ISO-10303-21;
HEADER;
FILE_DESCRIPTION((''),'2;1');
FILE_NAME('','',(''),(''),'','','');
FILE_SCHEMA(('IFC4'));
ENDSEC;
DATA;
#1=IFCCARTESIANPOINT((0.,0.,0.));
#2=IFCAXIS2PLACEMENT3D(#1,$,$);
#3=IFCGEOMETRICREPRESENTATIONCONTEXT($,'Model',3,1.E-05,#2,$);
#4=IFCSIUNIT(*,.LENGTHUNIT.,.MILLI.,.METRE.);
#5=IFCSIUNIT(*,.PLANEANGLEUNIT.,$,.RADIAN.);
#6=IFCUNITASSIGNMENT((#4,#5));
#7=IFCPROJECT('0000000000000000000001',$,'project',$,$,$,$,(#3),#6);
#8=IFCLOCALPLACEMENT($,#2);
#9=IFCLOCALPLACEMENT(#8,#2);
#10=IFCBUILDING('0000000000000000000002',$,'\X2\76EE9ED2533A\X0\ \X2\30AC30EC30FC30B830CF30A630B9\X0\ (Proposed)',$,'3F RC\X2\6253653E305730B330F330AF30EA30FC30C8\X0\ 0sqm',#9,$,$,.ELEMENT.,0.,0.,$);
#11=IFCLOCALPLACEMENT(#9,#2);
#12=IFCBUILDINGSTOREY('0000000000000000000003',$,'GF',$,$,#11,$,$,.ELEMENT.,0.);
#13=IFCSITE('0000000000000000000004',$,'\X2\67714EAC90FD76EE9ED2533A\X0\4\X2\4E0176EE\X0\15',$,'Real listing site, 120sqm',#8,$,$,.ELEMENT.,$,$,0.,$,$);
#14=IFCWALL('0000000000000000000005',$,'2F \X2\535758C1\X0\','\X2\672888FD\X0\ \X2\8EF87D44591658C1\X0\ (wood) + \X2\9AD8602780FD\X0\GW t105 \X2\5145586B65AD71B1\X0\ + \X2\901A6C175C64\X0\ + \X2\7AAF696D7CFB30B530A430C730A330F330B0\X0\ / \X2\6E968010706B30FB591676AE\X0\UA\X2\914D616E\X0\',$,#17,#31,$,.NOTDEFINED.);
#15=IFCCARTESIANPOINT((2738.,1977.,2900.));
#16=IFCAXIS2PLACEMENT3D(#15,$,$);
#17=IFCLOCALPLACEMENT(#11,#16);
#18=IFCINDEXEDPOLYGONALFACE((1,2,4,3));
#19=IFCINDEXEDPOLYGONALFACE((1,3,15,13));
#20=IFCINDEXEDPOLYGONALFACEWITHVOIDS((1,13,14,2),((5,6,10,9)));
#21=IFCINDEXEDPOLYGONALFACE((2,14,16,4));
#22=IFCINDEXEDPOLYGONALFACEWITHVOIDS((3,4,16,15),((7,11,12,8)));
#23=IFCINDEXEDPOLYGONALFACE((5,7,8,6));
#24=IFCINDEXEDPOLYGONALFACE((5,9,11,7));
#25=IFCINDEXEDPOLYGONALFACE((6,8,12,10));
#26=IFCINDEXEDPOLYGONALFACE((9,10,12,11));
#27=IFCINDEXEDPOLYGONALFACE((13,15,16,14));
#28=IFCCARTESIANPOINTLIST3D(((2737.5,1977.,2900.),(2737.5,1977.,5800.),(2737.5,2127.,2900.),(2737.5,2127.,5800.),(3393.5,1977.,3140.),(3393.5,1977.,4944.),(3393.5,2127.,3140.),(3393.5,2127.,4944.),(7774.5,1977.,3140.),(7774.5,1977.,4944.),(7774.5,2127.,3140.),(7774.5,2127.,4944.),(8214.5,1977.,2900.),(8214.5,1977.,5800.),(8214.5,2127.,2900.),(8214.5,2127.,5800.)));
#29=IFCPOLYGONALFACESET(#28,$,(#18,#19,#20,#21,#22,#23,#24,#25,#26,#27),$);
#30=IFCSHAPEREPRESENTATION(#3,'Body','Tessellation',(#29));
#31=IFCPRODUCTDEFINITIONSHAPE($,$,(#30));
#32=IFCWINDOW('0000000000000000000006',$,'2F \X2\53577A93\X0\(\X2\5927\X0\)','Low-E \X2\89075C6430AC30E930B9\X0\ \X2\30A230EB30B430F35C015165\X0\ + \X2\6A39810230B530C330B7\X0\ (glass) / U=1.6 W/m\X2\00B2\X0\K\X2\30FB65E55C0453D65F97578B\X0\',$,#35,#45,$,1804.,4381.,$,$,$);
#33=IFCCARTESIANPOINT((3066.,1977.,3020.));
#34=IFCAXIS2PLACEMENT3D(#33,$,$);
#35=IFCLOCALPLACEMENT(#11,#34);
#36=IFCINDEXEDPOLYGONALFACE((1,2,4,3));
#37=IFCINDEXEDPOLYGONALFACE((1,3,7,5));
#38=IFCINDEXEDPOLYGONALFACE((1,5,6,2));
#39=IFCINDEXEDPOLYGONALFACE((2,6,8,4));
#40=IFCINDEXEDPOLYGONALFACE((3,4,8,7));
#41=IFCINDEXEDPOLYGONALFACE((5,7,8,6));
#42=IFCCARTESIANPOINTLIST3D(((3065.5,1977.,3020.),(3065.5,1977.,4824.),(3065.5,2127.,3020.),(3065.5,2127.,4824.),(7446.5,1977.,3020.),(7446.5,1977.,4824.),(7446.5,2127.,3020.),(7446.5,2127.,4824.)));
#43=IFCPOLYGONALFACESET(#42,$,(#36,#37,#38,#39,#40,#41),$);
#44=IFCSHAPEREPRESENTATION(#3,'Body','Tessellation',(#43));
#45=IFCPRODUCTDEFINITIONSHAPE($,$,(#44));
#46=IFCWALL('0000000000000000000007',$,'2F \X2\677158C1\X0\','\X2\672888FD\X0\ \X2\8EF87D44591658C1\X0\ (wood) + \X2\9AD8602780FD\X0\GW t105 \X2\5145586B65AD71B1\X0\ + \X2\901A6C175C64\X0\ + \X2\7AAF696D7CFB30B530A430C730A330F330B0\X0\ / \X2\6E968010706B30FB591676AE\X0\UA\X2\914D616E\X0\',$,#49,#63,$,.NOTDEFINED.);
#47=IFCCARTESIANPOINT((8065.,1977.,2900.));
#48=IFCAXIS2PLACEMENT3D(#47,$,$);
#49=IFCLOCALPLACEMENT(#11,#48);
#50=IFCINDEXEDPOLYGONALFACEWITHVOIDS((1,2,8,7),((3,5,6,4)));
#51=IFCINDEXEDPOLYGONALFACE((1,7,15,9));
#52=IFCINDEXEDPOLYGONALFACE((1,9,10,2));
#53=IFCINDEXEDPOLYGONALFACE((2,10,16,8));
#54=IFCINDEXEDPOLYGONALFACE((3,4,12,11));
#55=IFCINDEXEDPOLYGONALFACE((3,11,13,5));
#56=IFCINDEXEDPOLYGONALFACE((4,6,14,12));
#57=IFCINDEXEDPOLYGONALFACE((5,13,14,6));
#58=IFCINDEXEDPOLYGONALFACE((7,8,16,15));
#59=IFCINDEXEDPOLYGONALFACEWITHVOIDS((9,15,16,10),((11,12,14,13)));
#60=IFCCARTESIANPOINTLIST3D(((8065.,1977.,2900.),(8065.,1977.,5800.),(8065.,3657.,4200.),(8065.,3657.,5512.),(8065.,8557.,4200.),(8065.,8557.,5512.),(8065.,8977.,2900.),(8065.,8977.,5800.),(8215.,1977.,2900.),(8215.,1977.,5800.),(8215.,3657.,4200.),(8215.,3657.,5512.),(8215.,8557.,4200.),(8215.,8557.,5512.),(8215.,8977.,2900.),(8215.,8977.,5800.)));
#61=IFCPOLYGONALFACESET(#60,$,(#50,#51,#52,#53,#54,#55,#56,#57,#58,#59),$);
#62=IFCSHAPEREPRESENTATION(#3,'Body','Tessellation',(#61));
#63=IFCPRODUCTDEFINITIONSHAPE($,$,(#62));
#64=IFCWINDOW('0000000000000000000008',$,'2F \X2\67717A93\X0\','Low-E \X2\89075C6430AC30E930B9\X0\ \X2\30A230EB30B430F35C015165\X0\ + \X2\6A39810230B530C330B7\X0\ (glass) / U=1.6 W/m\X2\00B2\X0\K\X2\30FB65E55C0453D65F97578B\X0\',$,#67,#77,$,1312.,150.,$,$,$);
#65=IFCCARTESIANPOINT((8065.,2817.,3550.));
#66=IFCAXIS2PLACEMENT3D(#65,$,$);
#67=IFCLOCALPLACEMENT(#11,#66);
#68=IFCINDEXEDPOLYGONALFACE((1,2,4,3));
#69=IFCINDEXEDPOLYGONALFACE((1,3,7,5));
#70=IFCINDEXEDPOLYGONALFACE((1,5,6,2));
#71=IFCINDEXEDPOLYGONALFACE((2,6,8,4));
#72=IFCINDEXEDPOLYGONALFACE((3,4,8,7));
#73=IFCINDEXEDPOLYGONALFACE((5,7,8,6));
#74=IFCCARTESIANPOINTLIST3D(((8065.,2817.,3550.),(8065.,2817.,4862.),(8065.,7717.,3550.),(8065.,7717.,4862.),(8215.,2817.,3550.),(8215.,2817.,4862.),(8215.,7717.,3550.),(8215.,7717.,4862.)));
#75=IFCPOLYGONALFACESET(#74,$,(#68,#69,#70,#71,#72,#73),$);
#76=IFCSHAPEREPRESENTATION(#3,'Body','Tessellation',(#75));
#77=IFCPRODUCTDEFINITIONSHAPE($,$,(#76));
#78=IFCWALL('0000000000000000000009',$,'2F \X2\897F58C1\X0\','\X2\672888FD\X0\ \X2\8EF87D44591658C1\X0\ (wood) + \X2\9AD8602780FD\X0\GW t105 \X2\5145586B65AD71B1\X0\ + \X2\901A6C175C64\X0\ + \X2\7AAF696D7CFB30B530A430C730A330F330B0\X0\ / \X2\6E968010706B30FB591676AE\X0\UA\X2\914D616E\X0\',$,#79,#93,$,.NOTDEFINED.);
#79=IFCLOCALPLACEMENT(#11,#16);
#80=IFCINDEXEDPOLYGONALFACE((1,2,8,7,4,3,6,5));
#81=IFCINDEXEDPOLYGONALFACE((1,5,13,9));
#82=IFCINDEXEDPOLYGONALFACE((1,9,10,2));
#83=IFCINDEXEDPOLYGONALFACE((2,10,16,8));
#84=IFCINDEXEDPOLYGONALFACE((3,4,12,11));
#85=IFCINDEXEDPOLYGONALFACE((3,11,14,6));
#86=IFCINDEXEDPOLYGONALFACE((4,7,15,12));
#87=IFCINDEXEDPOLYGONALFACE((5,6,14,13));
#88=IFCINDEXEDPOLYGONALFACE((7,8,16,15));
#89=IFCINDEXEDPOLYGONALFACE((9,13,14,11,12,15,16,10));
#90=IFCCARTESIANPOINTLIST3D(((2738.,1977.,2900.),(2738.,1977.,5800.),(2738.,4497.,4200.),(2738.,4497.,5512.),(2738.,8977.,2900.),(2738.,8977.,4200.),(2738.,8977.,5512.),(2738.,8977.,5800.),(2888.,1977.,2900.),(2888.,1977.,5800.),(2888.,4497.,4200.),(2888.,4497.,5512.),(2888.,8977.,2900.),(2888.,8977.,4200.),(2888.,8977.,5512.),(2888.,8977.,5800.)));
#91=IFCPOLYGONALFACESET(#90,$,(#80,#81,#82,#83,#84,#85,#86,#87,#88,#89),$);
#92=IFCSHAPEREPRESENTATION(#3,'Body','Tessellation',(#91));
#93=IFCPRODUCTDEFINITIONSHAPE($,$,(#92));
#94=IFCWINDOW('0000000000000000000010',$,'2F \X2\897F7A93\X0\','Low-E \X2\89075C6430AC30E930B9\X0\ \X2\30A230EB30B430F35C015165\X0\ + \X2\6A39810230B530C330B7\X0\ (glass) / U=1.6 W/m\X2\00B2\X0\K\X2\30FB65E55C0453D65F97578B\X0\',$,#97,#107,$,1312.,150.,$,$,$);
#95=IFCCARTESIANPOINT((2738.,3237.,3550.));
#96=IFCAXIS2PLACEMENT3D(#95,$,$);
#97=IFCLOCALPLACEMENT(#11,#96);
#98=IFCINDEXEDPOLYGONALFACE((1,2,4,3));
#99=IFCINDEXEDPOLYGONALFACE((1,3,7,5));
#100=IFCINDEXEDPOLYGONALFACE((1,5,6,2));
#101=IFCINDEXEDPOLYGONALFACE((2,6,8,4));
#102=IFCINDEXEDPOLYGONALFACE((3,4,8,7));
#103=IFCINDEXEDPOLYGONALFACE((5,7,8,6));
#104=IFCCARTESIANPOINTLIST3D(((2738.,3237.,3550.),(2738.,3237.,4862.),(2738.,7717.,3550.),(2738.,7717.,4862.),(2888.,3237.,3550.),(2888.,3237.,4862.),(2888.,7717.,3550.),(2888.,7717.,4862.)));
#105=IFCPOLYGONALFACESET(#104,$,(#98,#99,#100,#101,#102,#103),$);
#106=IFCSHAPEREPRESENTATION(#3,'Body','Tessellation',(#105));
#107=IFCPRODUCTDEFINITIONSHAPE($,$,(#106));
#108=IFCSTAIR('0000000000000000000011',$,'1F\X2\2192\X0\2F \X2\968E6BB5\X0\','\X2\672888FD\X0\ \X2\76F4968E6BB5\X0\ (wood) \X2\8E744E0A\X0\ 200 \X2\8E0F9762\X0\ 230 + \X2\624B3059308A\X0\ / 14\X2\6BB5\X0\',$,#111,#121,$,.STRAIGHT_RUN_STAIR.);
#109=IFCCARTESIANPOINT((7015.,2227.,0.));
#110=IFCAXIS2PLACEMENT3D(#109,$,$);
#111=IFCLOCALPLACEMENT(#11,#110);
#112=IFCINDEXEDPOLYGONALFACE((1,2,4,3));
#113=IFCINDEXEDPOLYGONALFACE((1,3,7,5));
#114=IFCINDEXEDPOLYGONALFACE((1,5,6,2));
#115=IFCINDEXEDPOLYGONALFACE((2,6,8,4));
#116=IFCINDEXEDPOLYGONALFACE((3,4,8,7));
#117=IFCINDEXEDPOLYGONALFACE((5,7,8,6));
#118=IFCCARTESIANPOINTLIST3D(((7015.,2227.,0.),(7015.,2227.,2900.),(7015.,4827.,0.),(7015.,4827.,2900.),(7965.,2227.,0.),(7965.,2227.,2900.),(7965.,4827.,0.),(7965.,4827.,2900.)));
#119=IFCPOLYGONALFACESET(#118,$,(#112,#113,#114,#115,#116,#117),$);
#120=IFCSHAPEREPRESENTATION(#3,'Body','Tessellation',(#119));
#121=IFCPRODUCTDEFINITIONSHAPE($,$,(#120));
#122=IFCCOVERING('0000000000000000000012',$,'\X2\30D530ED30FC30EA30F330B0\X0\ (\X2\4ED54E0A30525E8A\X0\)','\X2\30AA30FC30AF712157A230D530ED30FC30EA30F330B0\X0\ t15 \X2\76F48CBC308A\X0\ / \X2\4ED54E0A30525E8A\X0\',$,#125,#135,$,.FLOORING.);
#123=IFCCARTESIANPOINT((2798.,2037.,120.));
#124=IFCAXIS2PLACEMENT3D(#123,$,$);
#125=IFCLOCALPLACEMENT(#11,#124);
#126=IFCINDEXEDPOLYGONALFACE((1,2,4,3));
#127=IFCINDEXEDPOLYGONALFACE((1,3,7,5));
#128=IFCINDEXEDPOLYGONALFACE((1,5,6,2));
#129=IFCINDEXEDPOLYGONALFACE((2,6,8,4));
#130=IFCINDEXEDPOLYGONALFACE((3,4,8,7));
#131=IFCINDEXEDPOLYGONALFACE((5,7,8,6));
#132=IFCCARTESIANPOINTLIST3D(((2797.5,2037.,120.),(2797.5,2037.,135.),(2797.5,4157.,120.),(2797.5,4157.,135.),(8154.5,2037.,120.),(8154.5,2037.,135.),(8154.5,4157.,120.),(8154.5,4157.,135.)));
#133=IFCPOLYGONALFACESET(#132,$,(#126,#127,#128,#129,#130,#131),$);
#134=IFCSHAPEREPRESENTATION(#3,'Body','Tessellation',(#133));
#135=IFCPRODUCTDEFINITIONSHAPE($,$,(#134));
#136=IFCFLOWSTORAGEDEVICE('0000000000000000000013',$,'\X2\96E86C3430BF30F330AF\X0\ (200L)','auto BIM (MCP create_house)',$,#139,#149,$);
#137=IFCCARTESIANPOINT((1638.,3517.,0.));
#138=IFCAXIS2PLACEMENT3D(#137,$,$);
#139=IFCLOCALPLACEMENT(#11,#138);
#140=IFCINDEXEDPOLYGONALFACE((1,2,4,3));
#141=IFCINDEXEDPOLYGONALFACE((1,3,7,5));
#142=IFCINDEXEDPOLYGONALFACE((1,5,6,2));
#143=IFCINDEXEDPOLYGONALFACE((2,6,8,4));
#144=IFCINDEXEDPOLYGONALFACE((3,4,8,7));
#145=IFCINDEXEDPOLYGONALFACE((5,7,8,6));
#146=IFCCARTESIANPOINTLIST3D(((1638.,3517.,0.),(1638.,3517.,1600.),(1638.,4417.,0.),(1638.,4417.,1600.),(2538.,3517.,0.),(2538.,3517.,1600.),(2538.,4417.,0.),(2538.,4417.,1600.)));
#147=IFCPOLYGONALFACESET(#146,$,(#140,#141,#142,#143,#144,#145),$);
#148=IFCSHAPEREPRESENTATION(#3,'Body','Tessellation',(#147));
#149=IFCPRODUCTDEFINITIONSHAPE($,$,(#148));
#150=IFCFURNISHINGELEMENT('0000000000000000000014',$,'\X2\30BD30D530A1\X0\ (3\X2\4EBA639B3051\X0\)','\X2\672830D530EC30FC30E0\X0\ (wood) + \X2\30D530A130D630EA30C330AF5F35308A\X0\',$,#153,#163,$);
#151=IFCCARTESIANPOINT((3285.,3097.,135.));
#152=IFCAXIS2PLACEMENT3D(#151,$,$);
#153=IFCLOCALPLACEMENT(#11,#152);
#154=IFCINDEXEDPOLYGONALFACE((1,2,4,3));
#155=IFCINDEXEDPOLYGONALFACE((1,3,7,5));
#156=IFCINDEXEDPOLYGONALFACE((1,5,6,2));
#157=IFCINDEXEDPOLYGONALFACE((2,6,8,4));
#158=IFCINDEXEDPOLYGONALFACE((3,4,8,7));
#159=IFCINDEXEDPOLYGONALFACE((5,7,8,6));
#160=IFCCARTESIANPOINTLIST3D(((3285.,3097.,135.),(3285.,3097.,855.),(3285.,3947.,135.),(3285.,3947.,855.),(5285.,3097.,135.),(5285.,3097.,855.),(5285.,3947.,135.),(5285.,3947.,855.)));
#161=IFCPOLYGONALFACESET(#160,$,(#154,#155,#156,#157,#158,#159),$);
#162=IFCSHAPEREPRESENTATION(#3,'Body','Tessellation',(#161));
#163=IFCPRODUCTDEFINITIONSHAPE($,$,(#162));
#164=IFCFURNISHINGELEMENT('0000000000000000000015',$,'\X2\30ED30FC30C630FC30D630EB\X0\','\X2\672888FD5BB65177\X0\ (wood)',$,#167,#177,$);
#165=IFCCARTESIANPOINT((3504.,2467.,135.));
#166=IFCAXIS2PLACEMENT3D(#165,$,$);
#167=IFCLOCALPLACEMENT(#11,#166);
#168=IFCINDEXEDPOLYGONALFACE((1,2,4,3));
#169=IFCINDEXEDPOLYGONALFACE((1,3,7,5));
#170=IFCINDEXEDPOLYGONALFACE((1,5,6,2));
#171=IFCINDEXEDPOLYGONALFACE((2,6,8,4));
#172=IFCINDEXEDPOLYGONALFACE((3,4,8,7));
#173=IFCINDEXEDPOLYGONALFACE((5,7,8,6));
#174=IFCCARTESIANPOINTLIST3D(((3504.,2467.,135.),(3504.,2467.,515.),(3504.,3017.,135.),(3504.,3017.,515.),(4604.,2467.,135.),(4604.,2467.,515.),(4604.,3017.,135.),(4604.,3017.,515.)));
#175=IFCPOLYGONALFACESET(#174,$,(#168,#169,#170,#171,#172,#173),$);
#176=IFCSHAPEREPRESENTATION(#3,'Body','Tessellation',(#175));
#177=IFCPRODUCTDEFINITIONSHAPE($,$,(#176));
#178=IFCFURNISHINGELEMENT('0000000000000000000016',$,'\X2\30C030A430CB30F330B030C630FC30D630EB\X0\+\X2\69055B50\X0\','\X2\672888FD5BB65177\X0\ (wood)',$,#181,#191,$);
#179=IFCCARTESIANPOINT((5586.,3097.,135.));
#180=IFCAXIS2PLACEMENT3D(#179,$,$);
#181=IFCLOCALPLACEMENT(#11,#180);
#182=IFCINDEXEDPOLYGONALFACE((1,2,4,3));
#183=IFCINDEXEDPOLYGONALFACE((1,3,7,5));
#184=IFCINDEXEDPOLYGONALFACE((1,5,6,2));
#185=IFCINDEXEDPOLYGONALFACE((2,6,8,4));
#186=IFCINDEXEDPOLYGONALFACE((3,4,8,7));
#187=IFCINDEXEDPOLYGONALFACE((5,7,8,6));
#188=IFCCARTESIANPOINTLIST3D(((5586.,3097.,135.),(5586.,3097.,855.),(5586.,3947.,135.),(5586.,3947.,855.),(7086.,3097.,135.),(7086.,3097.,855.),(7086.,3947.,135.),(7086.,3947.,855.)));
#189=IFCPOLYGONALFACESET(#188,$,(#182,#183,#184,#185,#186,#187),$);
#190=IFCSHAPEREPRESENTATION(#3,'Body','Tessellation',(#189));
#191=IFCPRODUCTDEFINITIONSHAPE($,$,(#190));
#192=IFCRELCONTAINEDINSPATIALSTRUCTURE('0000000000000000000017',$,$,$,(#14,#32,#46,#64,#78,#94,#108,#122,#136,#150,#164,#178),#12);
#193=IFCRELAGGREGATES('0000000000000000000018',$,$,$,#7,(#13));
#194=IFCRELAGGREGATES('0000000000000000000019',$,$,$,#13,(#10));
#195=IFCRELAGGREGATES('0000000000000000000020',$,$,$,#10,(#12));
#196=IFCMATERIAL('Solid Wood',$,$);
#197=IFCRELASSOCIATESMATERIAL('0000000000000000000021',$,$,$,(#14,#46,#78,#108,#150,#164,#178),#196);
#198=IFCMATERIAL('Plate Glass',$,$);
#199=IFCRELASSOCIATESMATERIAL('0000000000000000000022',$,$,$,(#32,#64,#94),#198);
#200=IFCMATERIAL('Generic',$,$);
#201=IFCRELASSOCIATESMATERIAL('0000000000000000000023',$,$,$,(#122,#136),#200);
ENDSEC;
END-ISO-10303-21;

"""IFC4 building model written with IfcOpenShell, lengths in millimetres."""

from ifc_helpers import new_model, si_unit, frame, frame_2d, origin, place, context, project, spatial, rectangle, extrude, material, element, fill, save


model = new_model("IFC4")

# Units and contexts
model_context = context("Model", 3, precision=1e-05, world=origin())
ifc_project = project(units=[si_unit("LENGTHUNIT", "METRE", prefix="MILLI"), si_unit("PLANEANGLEUNIT", "RADIAN")], contexts=[model_context])

# Site, building, storey
site_placement = place(None, origin())
site = spatial("IfcSite", under=ifc_project, at=site_placement, Name="東京都目黒区4丁目15", ObjectType="Real listing site, 120sqm", CompositionType="ELEMENT", RefElevation=0.0)
building_placement = place(site_placement, origin())
building = spatial("IfcBuilding", under=site, at=building_placement, Name="目黒区 ガレージハウス (Proposed)", ObjectType="3F RC打放しコンクリート 0sqm", CompositionType="ELEMENT", ElevationOfRefHeight=0.0, ElevationOfTerrain=0.0)
storey_placement = place(building_placement, origin())
storey = spatial("IfcBuildingStorey", under=building, at=storey_placement, Name="GF", CompositionType="ELEMENT", Elevation=0.0)

# Shared definitions
ifc_material_1 = material(Name="Solid Wood")

# Shared definitions
ifc_material_2 = material(Name="Plate Glass")

# Walls, openings, windows
wall_1_placement = place(storey_placement, frame((2738.0, 1977.0, 2900.0)))
wall_1 = element("IfcWall", 1, at=wall_1_placement, inside=storey, material=ifc_material_1, Name="2F 南壁", Description="木製 軸組外壁 (wood) + 高性能GW t105 充填断熱 + 通気層 + 窯業系サイディング / 準耐火・外皮UA配慮", PredefinedType="NOTDEFINED", context=model_context, shape_type="SweptSolid", body=[
    extrude(rectangle(XDim=5477.0, YDim=150.0, at=frame_2d((2738.0, 75.0))), frame((2738.0, 1977.0, 2900.0)), (0.0, 0.0, 1.0), 2900.0),
])
opening_1_placement = place(storey_placement, frame((3066.0, 1977.0, 3020.0)))
opening_1 = element("IfcOpeningElement", 2, at=opening_1_placement, cuts=wall_1, PredefinedType="NOTDEFINED", context=model_context, shape_type="SweptSolid", body=[
    extrude(rectangle(XDim=4381.0, YDim=150.0, at=frame_2d((2190.0, 75.0))), frame((3066.0, 1977.0, 3020.0)), (0.0, 0.0, 1.0), 1804.0),
])
window_1_placement = place(storey_placement, frame((3066.0, 1977.0, 3020.0)))
window_1 = element("IfcWindow", 3, at=window_1_placement, inside=storey, material=ifc_material_2, Name="2F 南窓(大)", Description="Low-E 複層ガラス アルゴン封入 + 樹脂サッシ (glass) / U=1.6 W/m²K・日射取得型", OverallHeight=1804.0, OverallWidth=4381.0, context=model_context, shape_type="SweptSolid", body=[
    extrude(rectangle(XDim=4381.0, YDim=150.0, at=frame_2d((2190.0, 75.0))), frame((3066.0, 1977.0, 3020.0)), (0.0, 0.0, 1.0), 1804.0),
])
fill(opening_1, window_1)
wall_2_placement = place(storey_placement, frame((8065.0, 1977.0, 2900.0)))
wall_2 = element("IfcWall", 4, at=wall_2_placement, inside=storey, material=ifc_material_1, Name="2F 東壁", Description="木製 軸組外壁 (wood) + 高性能GW t105 充填断熱 + 通気層 + 窯業系サイディング / 準耐火・外皮UA配慮", PredefinedType="NOTDEFINED", context=model_context, shape_type="SweptSolid", body=[
    extrude(rectangle(XDim=150.0, YDim=7000.0, at=frame_2d((75.0, 3500.0))), frame((8065.0, 1977.0, 2900.0)), (0.0, 0.0, 1.0), 2900.0),
])
opening_2_placement = place(storey_placement, frame((8065.0, 2817.0, 3550.0)))
opening_2 = element("IfcOpeningElement", 5, at=opening_2_placement, cuts=wall_2, PredefinedType="NOTDEFINED", context=model_context, shape_type="SweptSolid", body=[
    extrude(rectangle(XDim=150.0, YDim=4900.0, at=frame_2d((75.0, 2450.0))), frame((8065.0, 2817.0, 3550.0)), (0.0, 0.0, 1.0), 1312.0),
])
window_2_placement = place(storey_placement, frame((8065.0, 2817.0, 3550.0)))
window_2 = element("IfcWindow", 6, at=window_2_placement, inside=storey, material=ifc_material_2, Name="2F 東窓", Description="Low-E 複層ガラス アルゴン封入 + 樹脂サッシ (glass) / U=1.6 W/m²K・日射取得型", OverallHeight=1312.0, OverallWidth=150.0, context=model_context, shape_type="SweptSolid", body=[
    extrude(rectangle(XDim=150.0, YDim=4900.0, at=frame_2d((75.0, 2450.0))), frame((8065.0, 2817.0, 3550.0)), (0.0, 0.0, 1.0), 1312.0),
])
fill(opening_2, window_2)
wall_3_placement = place(storey_placement, frame((2738.0, 1977.0, 2900.0)))
wall_3 = element("IfcWall", 7, at=wall_3_placement, inside=storey, material=ifc_material_1, Name="2F 西壁", Description="木製 軸組外壁 (wood) + 高性能GW t105 充填断熱 + 通気層 + 窯業系サイディング / 準耐火・外皮UA配慮", PredefinedType="NOTDEFINED", context=model_context, shape_type="SweptSolid", body=[
    extrude(rectangle(XDim=150.0, YDim=7000.0, at=frame_2d((75.0, 3500.0))), frame((2738.0, 1977.0, 2900.0)), (0.0, 0.0, 1.0), 2900.0),
])
opening_3_placement = place(storey_placement, frame((2738.0, 3237.0, 3550.0)))
opening_3 = element("IfcOpeningElement", 8, at=opening_3_placement, cuts=wall_3, PredefinedType="NOTDEFINED", context=model_context, shape_type="SweptSolid", body=[
    extrude(rectangle(XDim=150.0, YDim=4480.0, at=frame_2d((75.0, 2240.0))), frame((2738.0, 3237.0, 3550.0)), (0.0, 0.0, 1.0), 1312.0),
])
window_3_placement = place(storey_placement, frame((2738.0, 3237.0, 3550.0)))
window_3 = element("IfcWindow", 9, at=window_3_placement, inside=storey, material=ifc_material_2, Name="2F 西窓", Description="Low-E 複層ガラス アルゴン封入 + 樹脂サッシ (glass) / U=1.6 W/m²K・日射取得型", OverallHeight=1312.0, OverallWidth=150.0, context=model_context, shape_type="SweptSolid", body=[
    extrude(rectangle(XDim=150.0, YDim=4480.0, at=frame_2d((75.0, 2240.0))), frame((2738.0, 3237.0, 3550.0)), (0.0, 0.0, 1.0), 1312.0),
])
fill(opening_3, window_3)

# Stair
stair_placement = place(storey_placement, frame((7015.0, 2227.0, 0.0)))
element("IfcStair", 10, at=stair_placement, inside=storey, material=ifc_material_1, Name="1F→2F 階段", Description="木製 直階段 (wood) 蹴上 200 踏面 230 + 手すり / 14段", PredefinedType="STRAIGHT_RUN_STAIR", context=model_context, shape_type="SweptSolid", body=[
    extrude(rectangle(XDim=950.0, YDim=2600.0, at=frame_2d((475.0, 1300.0))), frame((7015.0, 2227.0, 0.0)), (0.0, 0.0, 1.0), 2900.0),
])

# Covering
ifc_material_3 = material(Name="Generic")
covering_placement = place(storey_placement, frame((2798.0, 2037.0, 120.0)))
element("IfcCovering", 11, at=covering_placement, inside=storey, material=ifc_material_3, Name="フローリング (仕上げ床)", Description="オーク無垢フローリング t15 直貼り / 仕上げ床", PredefinedType="FLOORING", context=model_context, shape_type="SweptSolid", body=[
    extrude(rectangle(XDim=5357.0, YDim=2120.0, at=frame_2d((2678.0, 1060.0))), frame((2798.0, 2037.0, 120.0)), (0.0, 0.0, 1.0), 15.0),
])

# Flow storage device
flow_storage_device_placement = place(storey_placement, frame((1638.0, 3517.0, 0.0)))
element("IfcFlowStorageDevice", 12, at=flow_storage_device_placement, inside=storey, material=ifc_material_3, Name="雨水タンク (200L)", Description="auto BIM (MCP create_house)", context=model_context, shape_type="SweptSolid", body=[
    extrude(rectangle(XDim=900.0, YDim=900.0, at=frame_2d((450.0, 450.0))), frame((1638.0, 3517.0, 0.0)), (0.0, 0.0, 1.0), 1600.0),
])

# Furnishing elements
furnishing_1_placement = place(storey_placement, frame((3285.0, 3097.0, 135.0)))
element("IfcFurnishingElement", 13, at=furnishing_1_placement, inside=storey, material=ifc_material_1, Name="ソファ (3人掛け)", Description="木フレーム (wood) + ファブリック張り", context=model_context, shape_type="SweptSolid", body=[
    extrude(rectangle(XDim=2000.0, YDim=850.0, at=frame_2d((1000.0, 425.0))), frame((3285.0, 3097.0, 135.0)), (0.0, 0.0, 1.0), 720.0),
])
furnishing_2_placement = place(storey_placement, frame((3504.0, 2467.0, 135.0)))
element("IfcFurnishingElement", 14, at=furnishing_2_placement, inside=storey, material=ifc_material_1, Name="ローテーブル", Description="木製家具 (wood)", context=model_context, shape_type="SweptSolid", body=[
    extrude(rectangle(XDim=1100.0, YDim=550.0, at=frame_2d((550.0, 275.0))), frame((3504.0, 2467.0, 135.0)), (0.0, 0.0, 1.0), 380.0),
])
furnishing_3_placement = place(storey_placement, frame((5586.0, 3097.0, 135.0)))
element("IfcFurnishingElement", 15, at=furnishing_3_placement, inside=storey, material=ifc_material_1, Name="ダイニングテーブル+椅子", Description="木製家具 (wood)", context=model_context, shape_type="SweptSolid", body=[
    extrude(rectangle(XDim=1500.0, YDim=850.0, at=frame_2d((750.0, 425.0))), frame((5586.0, 3097.0, 135.0)), (0.0, 0.0, 1.0), 720.0),
])

save(model, "model.ifc")
